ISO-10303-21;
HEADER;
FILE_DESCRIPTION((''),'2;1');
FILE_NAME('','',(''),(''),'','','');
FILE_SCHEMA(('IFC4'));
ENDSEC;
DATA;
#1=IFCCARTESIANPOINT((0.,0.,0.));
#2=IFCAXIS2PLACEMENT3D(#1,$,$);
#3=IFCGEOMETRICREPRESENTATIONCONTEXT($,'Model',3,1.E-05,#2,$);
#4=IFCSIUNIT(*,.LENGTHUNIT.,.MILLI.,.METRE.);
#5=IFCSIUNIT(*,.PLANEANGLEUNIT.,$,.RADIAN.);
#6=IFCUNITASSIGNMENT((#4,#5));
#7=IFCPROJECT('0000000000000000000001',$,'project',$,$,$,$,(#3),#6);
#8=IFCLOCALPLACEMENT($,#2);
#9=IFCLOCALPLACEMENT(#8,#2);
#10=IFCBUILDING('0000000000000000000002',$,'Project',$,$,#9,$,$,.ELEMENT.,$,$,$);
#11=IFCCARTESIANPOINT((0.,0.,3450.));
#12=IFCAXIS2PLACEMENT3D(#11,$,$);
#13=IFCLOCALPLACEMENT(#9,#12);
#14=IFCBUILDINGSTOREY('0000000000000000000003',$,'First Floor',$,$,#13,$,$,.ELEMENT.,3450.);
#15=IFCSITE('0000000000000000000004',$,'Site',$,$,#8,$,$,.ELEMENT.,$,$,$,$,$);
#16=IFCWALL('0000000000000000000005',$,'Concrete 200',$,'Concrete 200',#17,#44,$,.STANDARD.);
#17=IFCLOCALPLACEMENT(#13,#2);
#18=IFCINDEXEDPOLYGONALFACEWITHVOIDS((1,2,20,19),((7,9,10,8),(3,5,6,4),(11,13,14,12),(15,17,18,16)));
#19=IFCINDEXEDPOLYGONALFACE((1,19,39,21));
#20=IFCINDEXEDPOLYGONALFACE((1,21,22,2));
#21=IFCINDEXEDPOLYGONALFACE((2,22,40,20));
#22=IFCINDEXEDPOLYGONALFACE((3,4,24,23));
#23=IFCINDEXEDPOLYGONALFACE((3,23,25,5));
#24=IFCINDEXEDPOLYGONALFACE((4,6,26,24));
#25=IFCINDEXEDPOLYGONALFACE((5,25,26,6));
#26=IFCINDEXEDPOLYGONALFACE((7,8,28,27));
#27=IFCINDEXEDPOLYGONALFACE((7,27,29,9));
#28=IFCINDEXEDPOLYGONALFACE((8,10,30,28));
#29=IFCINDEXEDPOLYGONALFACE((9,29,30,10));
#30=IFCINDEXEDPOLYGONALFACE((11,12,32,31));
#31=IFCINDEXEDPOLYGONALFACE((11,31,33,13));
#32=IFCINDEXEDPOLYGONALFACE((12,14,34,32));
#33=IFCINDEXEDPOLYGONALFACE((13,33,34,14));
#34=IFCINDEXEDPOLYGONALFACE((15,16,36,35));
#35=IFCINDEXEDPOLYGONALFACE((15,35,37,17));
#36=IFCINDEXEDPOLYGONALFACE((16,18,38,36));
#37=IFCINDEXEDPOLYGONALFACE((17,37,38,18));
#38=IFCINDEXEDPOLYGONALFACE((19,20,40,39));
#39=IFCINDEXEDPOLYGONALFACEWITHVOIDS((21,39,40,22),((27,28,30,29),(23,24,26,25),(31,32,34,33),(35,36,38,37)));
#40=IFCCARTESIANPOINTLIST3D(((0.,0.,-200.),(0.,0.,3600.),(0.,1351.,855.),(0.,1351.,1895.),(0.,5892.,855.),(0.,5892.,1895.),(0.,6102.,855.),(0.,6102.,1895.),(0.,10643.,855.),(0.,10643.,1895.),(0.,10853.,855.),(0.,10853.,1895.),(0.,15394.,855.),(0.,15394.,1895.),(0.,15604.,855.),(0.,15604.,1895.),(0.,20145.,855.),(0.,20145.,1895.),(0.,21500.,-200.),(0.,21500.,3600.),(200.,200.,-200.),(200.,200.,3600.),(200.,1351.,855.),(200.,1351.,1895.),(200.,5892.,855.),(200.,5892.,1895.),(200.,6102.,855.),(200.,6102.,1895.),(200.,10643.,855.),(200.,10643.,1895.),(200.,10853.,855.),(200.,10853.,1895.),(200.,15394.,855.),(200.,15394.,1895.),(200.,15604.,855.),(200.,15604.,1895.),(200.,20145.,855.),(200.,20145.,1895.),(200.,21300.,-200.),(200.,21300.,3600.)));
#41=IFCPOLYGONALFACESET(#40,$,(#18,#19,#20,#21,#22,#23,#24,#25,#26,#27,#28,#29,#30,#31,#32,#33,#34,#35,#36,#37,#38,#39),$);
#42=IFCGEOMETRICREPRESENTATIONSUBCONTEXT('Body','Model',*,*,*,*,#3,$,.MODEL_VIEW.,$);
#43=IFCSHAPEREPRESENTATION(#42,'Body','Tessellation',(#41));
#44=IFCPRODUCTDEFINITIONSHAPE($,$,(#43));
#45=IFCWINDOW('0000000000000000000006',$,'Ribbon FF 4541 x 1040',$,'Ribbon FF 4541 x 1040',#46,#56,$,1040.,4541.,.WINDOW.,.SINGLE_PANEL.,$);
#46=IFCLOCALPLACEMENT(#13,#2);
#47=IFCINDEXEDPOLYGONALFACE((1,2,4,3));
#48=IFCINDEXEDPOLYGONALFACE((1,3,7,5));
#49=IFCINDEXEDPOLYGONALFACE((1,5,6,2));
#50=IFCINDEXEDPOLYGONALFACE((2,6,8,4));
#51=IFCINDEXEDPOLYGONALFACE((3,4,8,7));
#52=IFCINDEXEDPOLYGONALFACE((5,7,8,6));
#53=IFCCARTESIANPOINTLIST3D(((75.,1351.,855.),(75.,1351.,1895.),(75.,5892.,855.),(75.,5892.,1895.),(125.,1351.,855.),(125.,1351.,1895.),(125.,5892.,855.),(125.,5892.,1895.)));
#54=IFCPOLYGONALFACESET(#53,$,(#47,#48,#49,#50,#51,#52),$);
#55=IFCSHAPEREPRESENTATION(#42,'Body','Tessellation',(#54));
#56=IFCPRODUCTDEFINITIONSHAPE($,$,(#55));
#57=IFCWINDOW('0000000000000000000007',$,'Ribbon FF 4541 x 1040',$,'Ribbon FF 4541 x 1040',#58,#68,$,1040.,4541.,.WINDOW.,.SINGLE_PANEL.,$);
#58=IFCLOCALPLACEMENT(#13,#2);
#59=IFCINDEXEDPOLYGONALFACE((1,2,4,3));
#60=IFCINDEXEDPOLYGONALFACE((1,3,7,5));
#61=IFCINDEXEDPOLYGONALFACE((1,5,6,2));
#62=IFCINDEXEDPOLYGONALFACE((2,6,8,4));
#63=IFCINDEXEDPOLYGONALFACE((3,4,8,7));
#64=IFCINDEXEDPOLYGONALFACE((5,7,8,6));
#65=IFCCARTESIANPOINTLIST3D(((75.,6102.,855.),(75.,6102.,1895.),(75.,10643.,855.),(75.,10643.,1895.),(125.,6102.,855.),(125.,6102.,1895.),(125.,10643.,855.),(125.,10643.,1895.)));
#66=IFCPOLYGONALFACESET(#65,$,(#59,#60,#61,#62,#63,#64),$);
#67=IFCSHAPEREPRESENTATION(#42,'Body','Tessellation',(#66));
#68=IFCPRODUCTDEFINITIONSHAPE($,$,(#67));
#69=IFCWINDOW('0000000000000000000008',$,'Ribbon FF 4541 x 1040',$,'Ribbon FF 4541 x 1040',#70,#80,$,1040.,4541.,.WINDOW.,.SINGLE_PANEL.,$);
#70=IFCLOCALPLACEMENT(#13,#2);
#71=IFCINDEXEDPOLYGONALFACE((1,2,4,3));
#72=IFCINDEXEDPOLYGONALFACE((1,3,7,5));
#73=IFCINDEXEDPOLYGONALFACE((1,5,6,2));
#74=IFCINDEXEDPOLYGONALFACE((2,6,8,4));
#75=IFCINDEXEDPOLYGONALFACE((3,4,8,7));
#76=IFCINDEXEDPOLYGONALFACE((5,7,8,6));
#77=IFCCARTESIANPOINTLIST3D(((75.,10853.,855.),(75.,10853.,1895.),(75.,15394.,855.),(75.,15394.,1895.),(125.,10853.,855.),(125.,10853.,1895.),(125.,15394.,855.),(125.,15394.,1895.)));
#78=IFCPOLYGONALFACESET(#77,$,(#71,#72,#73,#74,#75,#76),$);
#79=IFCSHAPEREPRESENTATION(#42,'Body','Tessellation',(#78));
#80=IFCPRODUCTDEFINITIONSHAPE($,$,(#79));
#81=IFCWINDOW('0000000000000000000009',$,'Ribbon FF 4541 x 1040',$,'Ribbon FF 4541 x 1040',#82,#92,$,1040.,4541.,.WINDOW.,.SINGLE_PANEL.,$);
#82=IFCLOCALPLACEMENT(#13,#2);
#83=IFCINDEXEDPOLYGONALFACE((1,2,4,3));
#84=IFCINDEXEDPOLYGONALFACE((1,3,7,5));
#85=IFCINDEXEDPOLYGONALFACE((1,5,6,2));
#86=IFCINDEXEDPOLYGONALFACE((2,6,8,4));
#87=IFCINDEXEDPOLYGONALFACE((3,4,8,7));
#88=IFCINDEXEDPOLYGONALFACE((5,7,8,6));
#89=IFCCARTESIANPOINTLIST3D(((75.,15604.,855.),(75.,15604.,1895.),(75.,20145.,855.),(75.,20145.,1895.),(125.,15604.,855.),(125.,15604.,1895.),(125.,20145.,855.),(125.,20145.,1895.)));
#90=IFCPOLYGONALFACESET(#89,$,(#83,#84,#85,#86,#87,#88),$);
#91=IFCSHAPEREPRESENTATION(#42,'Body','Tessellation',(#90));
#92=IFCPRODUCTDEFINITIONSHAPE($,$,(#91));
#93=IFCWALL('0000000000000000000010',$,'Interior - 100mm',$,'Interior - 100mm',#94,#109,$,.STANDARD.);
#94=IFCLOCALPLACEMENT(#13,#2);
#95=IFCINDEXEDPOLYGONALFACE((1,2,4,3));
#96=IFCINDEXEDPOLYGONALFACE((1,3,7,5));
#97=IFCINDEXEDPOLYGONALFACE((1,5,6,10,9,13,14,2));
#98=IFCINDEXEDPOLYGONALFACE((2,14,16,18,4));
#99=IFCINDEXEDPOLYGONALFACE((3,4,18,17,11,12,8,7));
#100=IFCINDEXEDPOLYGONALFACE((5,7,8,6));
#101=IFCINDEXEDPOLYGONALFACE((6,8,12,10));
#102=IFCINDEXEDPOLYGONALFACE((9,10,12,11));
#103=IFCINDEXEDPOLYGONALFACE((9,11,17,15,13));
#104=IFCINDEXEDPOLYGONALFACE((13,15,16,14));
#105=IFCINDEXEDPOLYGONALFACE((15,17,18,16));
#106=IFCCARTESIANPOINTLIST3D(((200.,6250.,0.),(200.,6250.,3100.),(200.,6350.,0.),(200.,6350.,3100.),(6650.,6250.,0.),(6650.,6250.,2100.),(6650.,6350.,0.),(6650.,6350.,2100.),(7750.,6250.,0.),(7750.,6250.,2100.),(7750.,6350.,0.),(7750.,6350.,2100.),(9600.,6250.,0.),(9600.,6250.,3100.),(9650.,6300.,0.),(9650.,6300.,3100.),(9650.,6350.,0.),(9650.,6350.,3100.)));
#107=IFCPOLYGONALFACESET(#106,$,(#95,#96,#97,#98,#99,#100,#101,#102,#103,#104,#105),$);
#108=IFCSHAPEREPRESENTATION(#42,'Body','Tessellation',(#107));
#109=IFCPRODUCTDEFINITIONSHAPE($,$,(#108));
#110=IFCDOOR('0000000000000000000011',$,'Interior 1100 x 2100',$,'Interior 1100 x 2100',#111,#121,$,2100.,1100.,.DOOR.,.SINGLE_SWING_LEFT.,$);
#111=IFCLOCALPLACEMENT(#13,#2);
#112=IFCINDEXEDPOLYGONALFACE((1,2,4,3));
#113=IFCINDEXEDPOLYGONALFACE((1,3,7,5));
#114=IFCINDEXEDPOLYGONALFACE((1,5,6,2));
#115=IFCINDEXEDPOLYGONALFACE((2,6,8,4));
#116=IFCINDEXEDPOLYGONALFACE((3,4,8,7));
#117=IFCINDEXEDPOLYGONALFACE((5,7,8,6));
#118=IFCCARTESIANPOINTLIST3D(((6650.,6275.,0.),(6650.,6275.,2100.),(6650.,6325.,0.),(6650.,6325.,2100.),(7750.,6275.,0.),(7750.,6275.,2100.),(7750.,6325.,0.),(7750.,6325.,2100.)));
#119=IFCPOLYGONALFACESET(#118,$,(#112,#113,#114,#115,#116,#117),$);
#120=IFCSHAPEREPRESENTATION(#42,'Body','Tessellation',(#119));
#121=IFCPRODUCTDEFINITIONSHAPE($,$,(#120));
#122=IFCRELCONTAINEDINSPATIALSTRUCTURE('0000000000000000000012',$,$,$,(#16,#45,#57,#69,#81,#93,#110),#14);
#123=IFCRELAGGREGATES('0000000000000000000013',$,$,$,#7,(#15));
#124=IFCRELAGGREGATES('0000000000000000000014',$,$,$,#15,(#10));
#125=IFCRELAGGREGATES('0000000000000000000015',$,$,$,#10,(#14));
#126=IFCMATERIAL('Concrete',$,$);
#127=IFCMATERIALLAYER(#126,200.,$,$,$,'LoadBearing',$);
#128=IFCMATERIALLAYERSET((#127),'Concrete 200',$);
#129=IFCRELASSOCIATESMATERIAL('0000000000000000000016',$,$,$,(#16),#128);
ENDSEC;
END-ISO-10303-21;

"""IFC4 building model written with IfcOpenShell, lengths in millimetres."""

from ifc_helpers import new_model, si_unit, frame, frame_2d, origin, place, context, subcontext, project, spatial, polyline, rectangle, outline, extrude, material, layer, layer_set, layer_usage, element, fill, save


model = new_model("IFC4")

# Units and contexts
model_context = context("Model", 3, precision=1e-05, world=origin())
body_context = subcontext(model_context, "Body", "Model", "MODEL_VIEW")
ifc_project = project(units=[si_unit("LENGTHUNIT", "METRE", prefix="MILLI"), si_unit("PLANEANGLEUNIT", "RADIAN")], contexts=[model_context])

# Site, building, storey
site_placement = place(None, origin())
site = spatial("IfcSite", under=ifc_project, at=site_placement, Name="Site", CompositionType="ELEMENT")
building_placement = place(site_placement, origin())
building = spatial("IfcBuilding", under=site, at=building_placement, Name="Project", CompositionType="ELEMENT")
storey_placement = place(building_placement, frame((0.0, 0.0, 3450.0)))
storey = spatial("IfcBuildingStorey", under=building, at=storey_placement, Name="First Floor", CompositionType="ELEMENT", Elevation=3450.0)

# Shared definitions
ifc_material = material(Name="Concrete")

# Wall, openings, windows
ifc_layer_1 = layer(ifc_material, 200.0, Category="LoadBearing")
ifc_layer_set_1 = layer_set([ifc_layer_1], Name="Concrete 200")
ifc_layer_usage_1 = layer_usage(ifc_layer_set_1, "AXIS2", "NEGATIVE", 100.0)
wall_1_placement = place(storey_placement, frame((100.0, 100.0, -200.0), z_axis=(0.0, 0.0, 1.0), x_axis=(0.0, 1.0, 0.0)))
wall_1 = element("IfcWall", 1, at=wall_1_placement, inside=storey, material=ifc_layer_usage_1, Name="Concrete 200", ObjectType="Concrete 200", PredefinedType="STANDARD", context=body_context, shape_type="SweptSolid", body=[
    extrude(outline(polyline([(100.0, -100.0), (0.0, 0.0), (-100.0, 100.0), (21400.0, 100.0), (21300.0, 0.0), (21200.0, -100.0), (100.0, -100.0)])), origin(), (0.0, 0.0, 1.0), 3800.0),
])
opening_1_placement = place(wall_1_placement, frame((1251.0, 0.0, 1055.0), z_axis=(0.0, 0.0, 1.0), x_axis=(1.0, 0.0, 0.0)))
opening_1 = element("IfcOpeningElement", 2, at=opening_1_placement, cuts=wall_1, PredefinedType="OPENING", context=body_context, shape_type="SweptSolid", body=[
    extrude(rectangle(XDim=4541.0, YDim=220.0, at=frame_2d((2270.5, 0.0))), origin(), (0.0, 0.0, 1.0), 1040.0),
])
opening_2_placement = place(wall_1_placement, frame((6002.0, 0.0, 1055.0), z_axis=(0.0, 0.0, 1.0), x_axis=(1.0, 0.0, 0.0)))
opening_2 = element("IfcOpeningElement", 3, at=opening_2_placement, cuts=wall_1, PredefinedType="OPENING", context=body_context, shape_type="SweptSolid", body=[
    extrude(rectangle(XDim=4541.0, YDim=220.0, at=frame_2d((2270.5, 0.0))), origin(), (0.0, 0.0, 1.0), 1040.0),
])
opening_3_placement = place(wall_1_placement, frame((10753.0, 0.0, 1055.0), z_axis=(0.0, 0.0, 1.0), x_axis=(1.0, 0.0, 0.0)))
opening_3 = element("IfcOpeningElement", 4, at=opening_3_placement, cuts=wall_1, PredefinedType="OPENING", context=body_context, shape_type="SweptSolid", body=[
    extrude(rectangle(XDim=4541.0, YDim=220.0, at=frame_2d((2270.5, 0.0))), origin(), (0.0, 0.0, 1.0), 1040.0),
])
opening_4_placement = place(wall_1_placement, frame((15504.0, 0.0, 1055.0), z_axis=(0.0, 0.0, 1.0), x_axis=(1.0, 0.0, 0.0)))
opening_4 = element("IfcOpeningElement", 5, at=opening_4_placement, cuts=wall_1, PredefinedType="OPENING", context=body_context, shape_type="SweptSolid", body=[
    extrude(rectangle(XDim=4541.0, YDim=220.0, at=frame_2d((2270.5, 0.0))), origin(), (0.0, 0.0, 1.0), 1040.0),
])
window_1_placement = place(opening_1_placement, origin())
window_1 = element("IfcWindow", 6, at=window_1_placement, inside=storey, Name="Ribbon FF 4541 x 1040", ObjectType="Ribbon FF 4541 x 1040", OverallHeight=1040.0, OverallWidth=4541.0, PartitioningType="SINGLE_PANEL", PredefinedType="WINDOW", context=body_context, shape_type="SweptSolid", body=[
    extrude(rectangle(XDim=4541.0, YDim=50.0, at=frame_2d((2270.5, 0.0))), origin(), (0.0, 0.0, 1.0), 1040.0),
])
fill(opening_1, window_1)
window_2_placement = place(opening_2_placement, origin())
window_2 = element("IfcWindow", 7, at=window_2_placement, inside=storey, Name="Ribbon FF 4541 x 1040", ObjectType="Ribbon FF 4541 x 1040", OverallHeight=1040.0, OverallWidth=4541.0, PartitioningType="SINGLE_PANEL", PredefinedType="WINDOW", context=body_context, shape_type="SweptSolid", body=[
    extrude(rectangle(XDim=4541.0, YDim=50.0, at=frame_2d((2270.5, 0.0))), origin(), (0.0, 0.0, 1.0), 1040.0),
])
fill(opening_2, window_2)
window_3_placement = place(opening_3_placement, origin())
window_3 = element("IfcWindow", 8, at=window_3_placement, inside=storey, Name="Ribbon FF 4541 x 1040", ObjectType="Ribbon FF 4541 x 1040", OverallHeight=1040.0, OverallWidth=4541.0, PartitioningType="SINGLE_PANEL", PredefinedType="WINDOW", context=body_context, shape_type="SweptSolid", body=[
    extrude(rectangle(XDim=4541.0, YDim=50.0, at=frame_2d((2270.5, 0.0))), origin(), (0.0, 0.0, 1.0), 1040.0),
])
fill(opening_3, window_3)
window_4_placement = place(opening_4_placement, origin())
window_4 = element("IfcWindow", 9, at=window_4_placement, inside=storey, Name="Ribbon FF 4541 x 1040", ObjectType="Ribbon FF 4541 x 1040", OverallHeight=1040.0, OverallWidth=4541.0, PartitioningType="SINGLE_PANEL", PredefinedType="WINDOW", context=body_context, shape_type="SweptSolid", body=[
    extrude(rectangle(XDim=4541.0, YDim=50.0, at=frame_2d((2270.5, 0.0))), origin(), (0.0, 0.0, 1.0), 1040.0),
])
fill(opening_4, window_4)

# Wall, opening, door
wall_2_placement = place(storey_placement, frame((200.0, 6300.0, 0.0), z_axis=(0.0, 0.0, 1.0), x_axis=(1.0, 0.0, 0.0)))
wall_2 = element("IfcWall", 10, at=wall_2_placement, inside=storey, Name="Interior - 100mm", ObjectType="Interior - 100mm", PredefinedType="STANDARD", context=body_context, shape_type="SweptSolid", body=[
    extrude(outline(polyline([(0.0, -50.0), (0.0, 50.0), (9450.0, 50.0), (9450.0, 0.0), (9400.0, -50.0), (0.0, -50.0)])), origin(), (0.0, 0.0, 1.0), 3100.0),
])
opening_5_placement = place(wall_2_placement, frame((6450.0, 0.0, 0.0), z_axis=(0.0, 0.0, 1.0), x_axis=(1.0, 0.0, 0.0)))
opening_5 = element("IfcOpeningElement", 11, at=opening_5_placement, cuts=wall_2, PredefinedType="OPENING", context=body_context, shape_type="SweptSolid", body=[
    extrude(rectangle(XDim=1100.0, YDim=120.0, at=frame_2d((550.0, 0.0))), origin(), (0.0, 0.0, 1.0), 2100.0),
])
door_1_placement = place(opening_5_placement, origin())
door_1 = element("IfcDoor", 12, at=door_1_placement, inside=storey, Name="Interior 1100 x 2100", ObjectType="Interior 1100 x 2100", OperationType="SINGLE_SWING_LEFT", OverallHeight=2100.0, OverallWidth=1100.0, PredefinedType="DOOR", context=body_context, shape_type="SweptSolid", body=[
    extrude(rectangle(XDim=1100.0, YDim=50.0, at=frame_2d((550.0, 0.0))), origin(), (0.0, 0.0, 1.0), 2100.0),
])
fill(opening_5, door_1)

save(model, "model.ifc")
